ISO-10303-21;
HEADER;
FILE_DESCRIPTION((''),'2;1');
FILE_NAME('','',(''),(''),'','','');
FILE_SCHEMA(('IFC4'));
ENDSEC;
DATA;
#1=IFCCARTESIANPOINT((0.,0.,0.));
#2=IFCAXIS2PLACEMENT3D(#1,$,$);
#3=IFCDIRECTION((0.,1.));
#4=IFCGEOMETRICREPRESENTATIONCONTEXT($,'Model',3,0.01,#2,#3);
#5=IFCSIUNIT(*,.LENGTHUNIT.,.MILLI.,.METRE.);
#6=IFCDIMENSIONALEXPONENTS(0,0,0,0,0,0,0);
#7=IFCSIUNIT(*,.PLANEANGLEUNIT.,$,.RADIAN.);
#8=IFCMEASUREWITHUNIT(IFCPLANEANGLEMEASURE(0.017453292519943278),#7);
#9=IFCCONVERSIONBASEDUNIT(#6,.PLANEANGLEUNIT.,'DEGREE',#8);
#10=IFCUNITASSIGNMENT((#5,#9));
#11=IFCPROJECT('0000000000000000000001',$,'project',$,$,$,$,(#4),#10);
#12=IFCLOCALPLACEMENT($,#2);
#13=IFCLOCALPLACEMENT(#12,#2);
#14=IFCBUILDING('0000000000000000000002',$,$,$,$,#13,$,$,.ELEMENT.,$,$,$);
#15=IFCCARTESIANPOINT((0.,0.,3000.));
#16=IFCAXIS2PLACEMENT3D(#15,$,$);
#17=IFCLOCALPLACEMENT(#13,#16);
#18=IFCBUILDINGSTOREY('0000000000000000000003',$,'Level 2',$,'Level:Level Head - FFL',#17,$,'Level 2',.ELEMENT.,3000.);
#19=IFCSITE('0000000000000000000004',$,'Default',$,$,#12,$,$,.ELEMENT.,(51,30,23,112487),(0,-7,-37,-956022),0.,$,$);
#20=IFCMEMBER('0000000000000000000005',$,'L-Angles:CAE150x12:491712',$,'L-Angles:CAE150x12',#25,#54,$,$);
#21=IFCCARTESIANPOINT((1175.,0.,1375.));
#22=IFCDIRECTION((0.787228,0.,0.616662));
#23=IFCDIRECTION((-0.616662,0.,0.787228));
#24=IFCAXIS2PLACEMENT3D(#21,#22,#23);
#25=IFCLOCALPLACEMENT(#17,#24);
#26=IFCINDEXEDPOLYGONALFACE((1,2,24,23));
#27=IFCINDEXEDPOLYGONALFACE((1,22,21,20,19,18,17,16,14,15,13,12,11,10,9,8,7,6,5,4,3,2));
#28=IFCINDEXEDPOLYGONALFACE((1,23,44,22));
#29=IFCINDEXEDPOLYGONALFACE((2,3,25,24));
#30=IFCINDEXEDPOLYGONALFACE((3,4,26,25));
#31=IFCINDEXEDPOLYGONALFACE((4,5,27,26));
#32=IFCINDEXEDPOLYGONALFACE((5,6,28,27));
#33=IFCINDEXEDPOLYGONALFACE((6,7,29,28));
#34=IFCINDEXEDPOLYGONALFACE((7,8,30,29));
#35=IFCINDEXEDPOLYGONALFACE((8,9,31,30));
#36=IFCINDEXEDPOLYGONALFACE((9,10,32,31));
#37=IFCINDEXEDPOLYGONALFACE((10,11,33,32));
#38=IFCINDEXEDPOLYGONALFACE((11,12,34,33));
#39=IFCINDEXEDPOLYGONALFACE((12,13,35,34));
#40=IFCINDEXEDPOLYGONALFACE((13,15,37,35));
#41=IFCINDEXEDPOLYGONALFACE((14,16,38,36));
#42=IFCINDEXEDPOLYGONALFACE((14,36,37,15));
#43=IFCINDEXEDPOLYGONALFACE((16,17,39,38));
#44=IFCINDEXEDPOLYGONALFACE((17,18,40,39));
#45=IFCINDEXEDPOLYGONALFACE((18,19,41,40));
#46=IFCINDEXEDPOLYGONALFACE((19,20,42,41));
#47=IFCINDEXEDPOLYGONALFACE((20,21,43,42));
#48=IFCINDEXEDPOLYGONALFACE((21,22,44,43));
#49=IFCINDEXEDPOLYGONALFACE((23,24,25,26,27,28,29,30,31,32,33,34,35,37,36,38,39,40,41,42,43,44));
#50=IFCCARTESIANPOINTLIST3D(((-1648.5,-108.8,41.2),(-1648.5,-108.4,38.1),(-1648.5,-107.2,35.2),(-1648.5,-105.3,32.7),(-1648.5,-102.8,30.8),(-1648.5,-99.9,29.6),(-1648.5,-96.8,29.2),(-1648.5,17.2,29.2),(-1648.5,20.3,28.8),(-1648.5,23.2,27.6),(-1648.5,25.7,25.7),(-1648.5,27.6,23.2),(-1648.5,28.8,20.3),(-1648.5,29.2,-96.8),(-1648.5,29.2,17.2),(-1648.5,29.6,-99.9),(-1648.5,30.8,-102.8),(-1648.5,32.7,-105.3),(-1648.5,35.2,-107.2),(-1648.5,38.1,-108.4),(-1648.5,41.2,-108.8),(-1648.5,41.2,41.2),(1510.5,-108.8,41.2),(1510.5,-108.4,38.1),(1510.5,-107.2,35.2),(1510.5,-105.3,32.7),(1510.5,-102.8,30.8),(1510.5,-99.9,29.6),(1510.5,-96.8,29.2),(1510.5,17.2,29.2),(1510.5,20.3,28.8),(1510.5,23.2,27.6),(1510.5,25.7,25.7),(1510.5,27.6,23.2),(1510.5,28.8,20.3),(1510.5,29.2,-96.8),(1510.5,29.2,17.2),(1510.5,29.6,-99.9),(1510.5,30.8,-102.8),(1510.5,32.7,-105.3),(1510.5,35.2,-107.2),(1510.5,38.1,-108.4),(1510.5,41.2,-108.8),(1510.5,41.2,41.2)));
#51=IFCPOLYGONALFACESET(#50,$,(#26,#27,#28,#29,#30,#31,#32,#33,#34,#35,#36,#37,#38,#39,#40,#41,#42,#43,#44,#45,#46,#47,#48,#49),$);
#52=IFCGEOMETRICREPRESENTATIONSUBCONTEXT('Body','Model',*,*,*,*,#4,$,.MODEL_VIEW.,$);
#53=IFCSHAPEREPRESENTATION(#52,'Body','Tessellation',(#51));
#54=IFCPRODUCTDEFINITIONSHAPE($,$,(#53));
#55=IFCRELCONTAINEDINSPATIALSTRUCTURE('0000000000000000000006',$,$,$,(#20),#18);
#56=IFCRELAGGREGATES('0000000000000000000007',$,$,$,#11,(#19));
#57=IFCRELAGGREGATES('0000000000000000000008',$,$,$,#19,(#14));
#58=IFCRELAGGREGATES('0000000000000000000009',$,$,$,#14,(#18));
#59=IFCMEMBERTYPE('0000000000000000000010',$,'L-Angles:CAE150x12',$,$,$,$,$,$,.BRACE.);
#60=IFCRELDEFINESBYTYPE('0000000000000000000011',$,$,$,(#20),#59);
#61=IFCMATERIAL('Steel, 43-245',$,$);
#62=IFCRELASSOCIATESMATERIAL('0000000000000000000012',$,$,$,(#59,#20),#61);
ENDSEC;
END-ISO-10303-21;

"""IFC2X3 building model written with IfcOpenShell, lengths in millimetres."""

from ifc_helpers import new_model, entity, si_unit, converted_unit, direction, frame, frame_2d, origin, place, context, subcontext, project, spatial, polyline, circle_curve, parameter, trimmed, segment, composite_curve, outline, extrude, source, transform, mapped, material, type_object, type_shapes, element, save


model = new_model("IFC2X3")

# Units and contexts
model_context = context("Model", 3, precision=0.01, world=origin(), true_north=direction((0.0, 1.0)))
body_context = subcontext(model_context, "Body", "Model", "MODEL_VIEW")
ifc_project = project(units=[si_unit("LENGTHUNIT", "METRE", prefix="MILLI"), converted_unit("PLANEANGLEUNIT", "DEGREE", entity("IfcPlaneAngleMeasure", 0.017453292519943278), si_unit("PLANEANGLEUNIT", "RADIAN"), dimensions=[0, 0, 0, 0, 0, 0, 0])], contexts=[model_context])

# Site, building, storey
site_placement = place(None, origin())
site = spatial("IfcSite", under=ifc_project, at=site_placement, Name="Default", CompositionType="ELEMENT", RefLatitude=(51, 30, 23, 112487), RefLongitude=(0, -7, -37, -956022), RefElevation=0.0)
building_placement = place(site_placement, origin())
building = spatial("IfcBuilding", under=site, at=building_placement, CompositionType="ELEMENT")
storey_placement = place(building_placement, frame((0.0, 0.0, 3000.0)))
storey = spatial("IfcBuildingStorey", under=building, at=storey_placement, Name="Level 2", ObjectType="Level:Level Head - FFL", LongName="Level 2", CompositionType="ELEMENT", Elevation=3000.0)

# Shared definitions
ifc_material = material(Name="Steel, 43-245")

# Member
member_type_1 = type_object("IfcMemberType", Name="L-Angles:CAE150x12", PredefinedType="BRACE", material=ifc_material)
shared_shape_1 = source(origin(), body_context, "Body", "SweptSolid", [
    extrude(outline(composite_curve([segment(polyline([(-102.0, -48.0), (48.0, -48.0)]), True, "CONTINUOUS"), segment(polyline([(48.0, -48.0), (48.0, 102.0)]), True, "CONTINUOUS"), segment(trimmed(circle_curve(frame_2d((48.0, 90.0), x_axis=(0.0, 1.0)), 12.0), [parameter(0.0)], [parameter(90.0)], True, "PARAMETER"), True, "CONTINUOUS"), segment(polyline([(36.0, 90.0), (36.0, -24.0)]), True, "CONTINUOUS"), segment(trimmed(circle_curve(frame_2d((24.0, -24.0), x_axis=(1.0, 0.0)), 12.0), [parameter(270.0)], [parameter(0.0)], True, "PARAMETER"), False, "CONTINUOUS"), segment(polyline([(24.0, -36.0), (-90.0, -36.0)]), True, "CONTINUOUS"), segment(trimmed(circle_curve(frame_2d((-90.0, -48.0), x_axis=(0.0, 1.0)), 12.0), [parameter(0.0)], [parameter(90.0)], True, "PARAMETER"), True, "CONTINUOUS")], self_intersect=False)), frame((-1648.5, -6.8, -6.8), z_axis=(1.0, 0.0, 0.0), x_axis=(0.0, 0.0, 1.0)), (0.0, 0.0, 1.0), 3159.0),
])
type_shapes(member_type_1, [shared_shape_1])
for number, where, z_axis, x_axis, name in (
    (1, (1175.0, 0.0, 1375.0), (0.787228, 0.0, 0.616662), (-0.616662, 0.0, 0.787228), "L-Angles:CAE150x12:491712"),
):
    element("IfcMember", number, at=place(storey_placement, frame(where, z_axis=z_axis, x_axis=x_axis)), inside=storey, type_object=member_type_1, material=ifc_material, Name=name, ObjectType="L-Angles:CAE150x12", context=body_context, shape_type="MappedRepresentation", body=[
        mapped(shared_shape_1, transform((0.0, 0.0, 0.0), scale=1.0)),
    ])

save(model, "model.ifc")
